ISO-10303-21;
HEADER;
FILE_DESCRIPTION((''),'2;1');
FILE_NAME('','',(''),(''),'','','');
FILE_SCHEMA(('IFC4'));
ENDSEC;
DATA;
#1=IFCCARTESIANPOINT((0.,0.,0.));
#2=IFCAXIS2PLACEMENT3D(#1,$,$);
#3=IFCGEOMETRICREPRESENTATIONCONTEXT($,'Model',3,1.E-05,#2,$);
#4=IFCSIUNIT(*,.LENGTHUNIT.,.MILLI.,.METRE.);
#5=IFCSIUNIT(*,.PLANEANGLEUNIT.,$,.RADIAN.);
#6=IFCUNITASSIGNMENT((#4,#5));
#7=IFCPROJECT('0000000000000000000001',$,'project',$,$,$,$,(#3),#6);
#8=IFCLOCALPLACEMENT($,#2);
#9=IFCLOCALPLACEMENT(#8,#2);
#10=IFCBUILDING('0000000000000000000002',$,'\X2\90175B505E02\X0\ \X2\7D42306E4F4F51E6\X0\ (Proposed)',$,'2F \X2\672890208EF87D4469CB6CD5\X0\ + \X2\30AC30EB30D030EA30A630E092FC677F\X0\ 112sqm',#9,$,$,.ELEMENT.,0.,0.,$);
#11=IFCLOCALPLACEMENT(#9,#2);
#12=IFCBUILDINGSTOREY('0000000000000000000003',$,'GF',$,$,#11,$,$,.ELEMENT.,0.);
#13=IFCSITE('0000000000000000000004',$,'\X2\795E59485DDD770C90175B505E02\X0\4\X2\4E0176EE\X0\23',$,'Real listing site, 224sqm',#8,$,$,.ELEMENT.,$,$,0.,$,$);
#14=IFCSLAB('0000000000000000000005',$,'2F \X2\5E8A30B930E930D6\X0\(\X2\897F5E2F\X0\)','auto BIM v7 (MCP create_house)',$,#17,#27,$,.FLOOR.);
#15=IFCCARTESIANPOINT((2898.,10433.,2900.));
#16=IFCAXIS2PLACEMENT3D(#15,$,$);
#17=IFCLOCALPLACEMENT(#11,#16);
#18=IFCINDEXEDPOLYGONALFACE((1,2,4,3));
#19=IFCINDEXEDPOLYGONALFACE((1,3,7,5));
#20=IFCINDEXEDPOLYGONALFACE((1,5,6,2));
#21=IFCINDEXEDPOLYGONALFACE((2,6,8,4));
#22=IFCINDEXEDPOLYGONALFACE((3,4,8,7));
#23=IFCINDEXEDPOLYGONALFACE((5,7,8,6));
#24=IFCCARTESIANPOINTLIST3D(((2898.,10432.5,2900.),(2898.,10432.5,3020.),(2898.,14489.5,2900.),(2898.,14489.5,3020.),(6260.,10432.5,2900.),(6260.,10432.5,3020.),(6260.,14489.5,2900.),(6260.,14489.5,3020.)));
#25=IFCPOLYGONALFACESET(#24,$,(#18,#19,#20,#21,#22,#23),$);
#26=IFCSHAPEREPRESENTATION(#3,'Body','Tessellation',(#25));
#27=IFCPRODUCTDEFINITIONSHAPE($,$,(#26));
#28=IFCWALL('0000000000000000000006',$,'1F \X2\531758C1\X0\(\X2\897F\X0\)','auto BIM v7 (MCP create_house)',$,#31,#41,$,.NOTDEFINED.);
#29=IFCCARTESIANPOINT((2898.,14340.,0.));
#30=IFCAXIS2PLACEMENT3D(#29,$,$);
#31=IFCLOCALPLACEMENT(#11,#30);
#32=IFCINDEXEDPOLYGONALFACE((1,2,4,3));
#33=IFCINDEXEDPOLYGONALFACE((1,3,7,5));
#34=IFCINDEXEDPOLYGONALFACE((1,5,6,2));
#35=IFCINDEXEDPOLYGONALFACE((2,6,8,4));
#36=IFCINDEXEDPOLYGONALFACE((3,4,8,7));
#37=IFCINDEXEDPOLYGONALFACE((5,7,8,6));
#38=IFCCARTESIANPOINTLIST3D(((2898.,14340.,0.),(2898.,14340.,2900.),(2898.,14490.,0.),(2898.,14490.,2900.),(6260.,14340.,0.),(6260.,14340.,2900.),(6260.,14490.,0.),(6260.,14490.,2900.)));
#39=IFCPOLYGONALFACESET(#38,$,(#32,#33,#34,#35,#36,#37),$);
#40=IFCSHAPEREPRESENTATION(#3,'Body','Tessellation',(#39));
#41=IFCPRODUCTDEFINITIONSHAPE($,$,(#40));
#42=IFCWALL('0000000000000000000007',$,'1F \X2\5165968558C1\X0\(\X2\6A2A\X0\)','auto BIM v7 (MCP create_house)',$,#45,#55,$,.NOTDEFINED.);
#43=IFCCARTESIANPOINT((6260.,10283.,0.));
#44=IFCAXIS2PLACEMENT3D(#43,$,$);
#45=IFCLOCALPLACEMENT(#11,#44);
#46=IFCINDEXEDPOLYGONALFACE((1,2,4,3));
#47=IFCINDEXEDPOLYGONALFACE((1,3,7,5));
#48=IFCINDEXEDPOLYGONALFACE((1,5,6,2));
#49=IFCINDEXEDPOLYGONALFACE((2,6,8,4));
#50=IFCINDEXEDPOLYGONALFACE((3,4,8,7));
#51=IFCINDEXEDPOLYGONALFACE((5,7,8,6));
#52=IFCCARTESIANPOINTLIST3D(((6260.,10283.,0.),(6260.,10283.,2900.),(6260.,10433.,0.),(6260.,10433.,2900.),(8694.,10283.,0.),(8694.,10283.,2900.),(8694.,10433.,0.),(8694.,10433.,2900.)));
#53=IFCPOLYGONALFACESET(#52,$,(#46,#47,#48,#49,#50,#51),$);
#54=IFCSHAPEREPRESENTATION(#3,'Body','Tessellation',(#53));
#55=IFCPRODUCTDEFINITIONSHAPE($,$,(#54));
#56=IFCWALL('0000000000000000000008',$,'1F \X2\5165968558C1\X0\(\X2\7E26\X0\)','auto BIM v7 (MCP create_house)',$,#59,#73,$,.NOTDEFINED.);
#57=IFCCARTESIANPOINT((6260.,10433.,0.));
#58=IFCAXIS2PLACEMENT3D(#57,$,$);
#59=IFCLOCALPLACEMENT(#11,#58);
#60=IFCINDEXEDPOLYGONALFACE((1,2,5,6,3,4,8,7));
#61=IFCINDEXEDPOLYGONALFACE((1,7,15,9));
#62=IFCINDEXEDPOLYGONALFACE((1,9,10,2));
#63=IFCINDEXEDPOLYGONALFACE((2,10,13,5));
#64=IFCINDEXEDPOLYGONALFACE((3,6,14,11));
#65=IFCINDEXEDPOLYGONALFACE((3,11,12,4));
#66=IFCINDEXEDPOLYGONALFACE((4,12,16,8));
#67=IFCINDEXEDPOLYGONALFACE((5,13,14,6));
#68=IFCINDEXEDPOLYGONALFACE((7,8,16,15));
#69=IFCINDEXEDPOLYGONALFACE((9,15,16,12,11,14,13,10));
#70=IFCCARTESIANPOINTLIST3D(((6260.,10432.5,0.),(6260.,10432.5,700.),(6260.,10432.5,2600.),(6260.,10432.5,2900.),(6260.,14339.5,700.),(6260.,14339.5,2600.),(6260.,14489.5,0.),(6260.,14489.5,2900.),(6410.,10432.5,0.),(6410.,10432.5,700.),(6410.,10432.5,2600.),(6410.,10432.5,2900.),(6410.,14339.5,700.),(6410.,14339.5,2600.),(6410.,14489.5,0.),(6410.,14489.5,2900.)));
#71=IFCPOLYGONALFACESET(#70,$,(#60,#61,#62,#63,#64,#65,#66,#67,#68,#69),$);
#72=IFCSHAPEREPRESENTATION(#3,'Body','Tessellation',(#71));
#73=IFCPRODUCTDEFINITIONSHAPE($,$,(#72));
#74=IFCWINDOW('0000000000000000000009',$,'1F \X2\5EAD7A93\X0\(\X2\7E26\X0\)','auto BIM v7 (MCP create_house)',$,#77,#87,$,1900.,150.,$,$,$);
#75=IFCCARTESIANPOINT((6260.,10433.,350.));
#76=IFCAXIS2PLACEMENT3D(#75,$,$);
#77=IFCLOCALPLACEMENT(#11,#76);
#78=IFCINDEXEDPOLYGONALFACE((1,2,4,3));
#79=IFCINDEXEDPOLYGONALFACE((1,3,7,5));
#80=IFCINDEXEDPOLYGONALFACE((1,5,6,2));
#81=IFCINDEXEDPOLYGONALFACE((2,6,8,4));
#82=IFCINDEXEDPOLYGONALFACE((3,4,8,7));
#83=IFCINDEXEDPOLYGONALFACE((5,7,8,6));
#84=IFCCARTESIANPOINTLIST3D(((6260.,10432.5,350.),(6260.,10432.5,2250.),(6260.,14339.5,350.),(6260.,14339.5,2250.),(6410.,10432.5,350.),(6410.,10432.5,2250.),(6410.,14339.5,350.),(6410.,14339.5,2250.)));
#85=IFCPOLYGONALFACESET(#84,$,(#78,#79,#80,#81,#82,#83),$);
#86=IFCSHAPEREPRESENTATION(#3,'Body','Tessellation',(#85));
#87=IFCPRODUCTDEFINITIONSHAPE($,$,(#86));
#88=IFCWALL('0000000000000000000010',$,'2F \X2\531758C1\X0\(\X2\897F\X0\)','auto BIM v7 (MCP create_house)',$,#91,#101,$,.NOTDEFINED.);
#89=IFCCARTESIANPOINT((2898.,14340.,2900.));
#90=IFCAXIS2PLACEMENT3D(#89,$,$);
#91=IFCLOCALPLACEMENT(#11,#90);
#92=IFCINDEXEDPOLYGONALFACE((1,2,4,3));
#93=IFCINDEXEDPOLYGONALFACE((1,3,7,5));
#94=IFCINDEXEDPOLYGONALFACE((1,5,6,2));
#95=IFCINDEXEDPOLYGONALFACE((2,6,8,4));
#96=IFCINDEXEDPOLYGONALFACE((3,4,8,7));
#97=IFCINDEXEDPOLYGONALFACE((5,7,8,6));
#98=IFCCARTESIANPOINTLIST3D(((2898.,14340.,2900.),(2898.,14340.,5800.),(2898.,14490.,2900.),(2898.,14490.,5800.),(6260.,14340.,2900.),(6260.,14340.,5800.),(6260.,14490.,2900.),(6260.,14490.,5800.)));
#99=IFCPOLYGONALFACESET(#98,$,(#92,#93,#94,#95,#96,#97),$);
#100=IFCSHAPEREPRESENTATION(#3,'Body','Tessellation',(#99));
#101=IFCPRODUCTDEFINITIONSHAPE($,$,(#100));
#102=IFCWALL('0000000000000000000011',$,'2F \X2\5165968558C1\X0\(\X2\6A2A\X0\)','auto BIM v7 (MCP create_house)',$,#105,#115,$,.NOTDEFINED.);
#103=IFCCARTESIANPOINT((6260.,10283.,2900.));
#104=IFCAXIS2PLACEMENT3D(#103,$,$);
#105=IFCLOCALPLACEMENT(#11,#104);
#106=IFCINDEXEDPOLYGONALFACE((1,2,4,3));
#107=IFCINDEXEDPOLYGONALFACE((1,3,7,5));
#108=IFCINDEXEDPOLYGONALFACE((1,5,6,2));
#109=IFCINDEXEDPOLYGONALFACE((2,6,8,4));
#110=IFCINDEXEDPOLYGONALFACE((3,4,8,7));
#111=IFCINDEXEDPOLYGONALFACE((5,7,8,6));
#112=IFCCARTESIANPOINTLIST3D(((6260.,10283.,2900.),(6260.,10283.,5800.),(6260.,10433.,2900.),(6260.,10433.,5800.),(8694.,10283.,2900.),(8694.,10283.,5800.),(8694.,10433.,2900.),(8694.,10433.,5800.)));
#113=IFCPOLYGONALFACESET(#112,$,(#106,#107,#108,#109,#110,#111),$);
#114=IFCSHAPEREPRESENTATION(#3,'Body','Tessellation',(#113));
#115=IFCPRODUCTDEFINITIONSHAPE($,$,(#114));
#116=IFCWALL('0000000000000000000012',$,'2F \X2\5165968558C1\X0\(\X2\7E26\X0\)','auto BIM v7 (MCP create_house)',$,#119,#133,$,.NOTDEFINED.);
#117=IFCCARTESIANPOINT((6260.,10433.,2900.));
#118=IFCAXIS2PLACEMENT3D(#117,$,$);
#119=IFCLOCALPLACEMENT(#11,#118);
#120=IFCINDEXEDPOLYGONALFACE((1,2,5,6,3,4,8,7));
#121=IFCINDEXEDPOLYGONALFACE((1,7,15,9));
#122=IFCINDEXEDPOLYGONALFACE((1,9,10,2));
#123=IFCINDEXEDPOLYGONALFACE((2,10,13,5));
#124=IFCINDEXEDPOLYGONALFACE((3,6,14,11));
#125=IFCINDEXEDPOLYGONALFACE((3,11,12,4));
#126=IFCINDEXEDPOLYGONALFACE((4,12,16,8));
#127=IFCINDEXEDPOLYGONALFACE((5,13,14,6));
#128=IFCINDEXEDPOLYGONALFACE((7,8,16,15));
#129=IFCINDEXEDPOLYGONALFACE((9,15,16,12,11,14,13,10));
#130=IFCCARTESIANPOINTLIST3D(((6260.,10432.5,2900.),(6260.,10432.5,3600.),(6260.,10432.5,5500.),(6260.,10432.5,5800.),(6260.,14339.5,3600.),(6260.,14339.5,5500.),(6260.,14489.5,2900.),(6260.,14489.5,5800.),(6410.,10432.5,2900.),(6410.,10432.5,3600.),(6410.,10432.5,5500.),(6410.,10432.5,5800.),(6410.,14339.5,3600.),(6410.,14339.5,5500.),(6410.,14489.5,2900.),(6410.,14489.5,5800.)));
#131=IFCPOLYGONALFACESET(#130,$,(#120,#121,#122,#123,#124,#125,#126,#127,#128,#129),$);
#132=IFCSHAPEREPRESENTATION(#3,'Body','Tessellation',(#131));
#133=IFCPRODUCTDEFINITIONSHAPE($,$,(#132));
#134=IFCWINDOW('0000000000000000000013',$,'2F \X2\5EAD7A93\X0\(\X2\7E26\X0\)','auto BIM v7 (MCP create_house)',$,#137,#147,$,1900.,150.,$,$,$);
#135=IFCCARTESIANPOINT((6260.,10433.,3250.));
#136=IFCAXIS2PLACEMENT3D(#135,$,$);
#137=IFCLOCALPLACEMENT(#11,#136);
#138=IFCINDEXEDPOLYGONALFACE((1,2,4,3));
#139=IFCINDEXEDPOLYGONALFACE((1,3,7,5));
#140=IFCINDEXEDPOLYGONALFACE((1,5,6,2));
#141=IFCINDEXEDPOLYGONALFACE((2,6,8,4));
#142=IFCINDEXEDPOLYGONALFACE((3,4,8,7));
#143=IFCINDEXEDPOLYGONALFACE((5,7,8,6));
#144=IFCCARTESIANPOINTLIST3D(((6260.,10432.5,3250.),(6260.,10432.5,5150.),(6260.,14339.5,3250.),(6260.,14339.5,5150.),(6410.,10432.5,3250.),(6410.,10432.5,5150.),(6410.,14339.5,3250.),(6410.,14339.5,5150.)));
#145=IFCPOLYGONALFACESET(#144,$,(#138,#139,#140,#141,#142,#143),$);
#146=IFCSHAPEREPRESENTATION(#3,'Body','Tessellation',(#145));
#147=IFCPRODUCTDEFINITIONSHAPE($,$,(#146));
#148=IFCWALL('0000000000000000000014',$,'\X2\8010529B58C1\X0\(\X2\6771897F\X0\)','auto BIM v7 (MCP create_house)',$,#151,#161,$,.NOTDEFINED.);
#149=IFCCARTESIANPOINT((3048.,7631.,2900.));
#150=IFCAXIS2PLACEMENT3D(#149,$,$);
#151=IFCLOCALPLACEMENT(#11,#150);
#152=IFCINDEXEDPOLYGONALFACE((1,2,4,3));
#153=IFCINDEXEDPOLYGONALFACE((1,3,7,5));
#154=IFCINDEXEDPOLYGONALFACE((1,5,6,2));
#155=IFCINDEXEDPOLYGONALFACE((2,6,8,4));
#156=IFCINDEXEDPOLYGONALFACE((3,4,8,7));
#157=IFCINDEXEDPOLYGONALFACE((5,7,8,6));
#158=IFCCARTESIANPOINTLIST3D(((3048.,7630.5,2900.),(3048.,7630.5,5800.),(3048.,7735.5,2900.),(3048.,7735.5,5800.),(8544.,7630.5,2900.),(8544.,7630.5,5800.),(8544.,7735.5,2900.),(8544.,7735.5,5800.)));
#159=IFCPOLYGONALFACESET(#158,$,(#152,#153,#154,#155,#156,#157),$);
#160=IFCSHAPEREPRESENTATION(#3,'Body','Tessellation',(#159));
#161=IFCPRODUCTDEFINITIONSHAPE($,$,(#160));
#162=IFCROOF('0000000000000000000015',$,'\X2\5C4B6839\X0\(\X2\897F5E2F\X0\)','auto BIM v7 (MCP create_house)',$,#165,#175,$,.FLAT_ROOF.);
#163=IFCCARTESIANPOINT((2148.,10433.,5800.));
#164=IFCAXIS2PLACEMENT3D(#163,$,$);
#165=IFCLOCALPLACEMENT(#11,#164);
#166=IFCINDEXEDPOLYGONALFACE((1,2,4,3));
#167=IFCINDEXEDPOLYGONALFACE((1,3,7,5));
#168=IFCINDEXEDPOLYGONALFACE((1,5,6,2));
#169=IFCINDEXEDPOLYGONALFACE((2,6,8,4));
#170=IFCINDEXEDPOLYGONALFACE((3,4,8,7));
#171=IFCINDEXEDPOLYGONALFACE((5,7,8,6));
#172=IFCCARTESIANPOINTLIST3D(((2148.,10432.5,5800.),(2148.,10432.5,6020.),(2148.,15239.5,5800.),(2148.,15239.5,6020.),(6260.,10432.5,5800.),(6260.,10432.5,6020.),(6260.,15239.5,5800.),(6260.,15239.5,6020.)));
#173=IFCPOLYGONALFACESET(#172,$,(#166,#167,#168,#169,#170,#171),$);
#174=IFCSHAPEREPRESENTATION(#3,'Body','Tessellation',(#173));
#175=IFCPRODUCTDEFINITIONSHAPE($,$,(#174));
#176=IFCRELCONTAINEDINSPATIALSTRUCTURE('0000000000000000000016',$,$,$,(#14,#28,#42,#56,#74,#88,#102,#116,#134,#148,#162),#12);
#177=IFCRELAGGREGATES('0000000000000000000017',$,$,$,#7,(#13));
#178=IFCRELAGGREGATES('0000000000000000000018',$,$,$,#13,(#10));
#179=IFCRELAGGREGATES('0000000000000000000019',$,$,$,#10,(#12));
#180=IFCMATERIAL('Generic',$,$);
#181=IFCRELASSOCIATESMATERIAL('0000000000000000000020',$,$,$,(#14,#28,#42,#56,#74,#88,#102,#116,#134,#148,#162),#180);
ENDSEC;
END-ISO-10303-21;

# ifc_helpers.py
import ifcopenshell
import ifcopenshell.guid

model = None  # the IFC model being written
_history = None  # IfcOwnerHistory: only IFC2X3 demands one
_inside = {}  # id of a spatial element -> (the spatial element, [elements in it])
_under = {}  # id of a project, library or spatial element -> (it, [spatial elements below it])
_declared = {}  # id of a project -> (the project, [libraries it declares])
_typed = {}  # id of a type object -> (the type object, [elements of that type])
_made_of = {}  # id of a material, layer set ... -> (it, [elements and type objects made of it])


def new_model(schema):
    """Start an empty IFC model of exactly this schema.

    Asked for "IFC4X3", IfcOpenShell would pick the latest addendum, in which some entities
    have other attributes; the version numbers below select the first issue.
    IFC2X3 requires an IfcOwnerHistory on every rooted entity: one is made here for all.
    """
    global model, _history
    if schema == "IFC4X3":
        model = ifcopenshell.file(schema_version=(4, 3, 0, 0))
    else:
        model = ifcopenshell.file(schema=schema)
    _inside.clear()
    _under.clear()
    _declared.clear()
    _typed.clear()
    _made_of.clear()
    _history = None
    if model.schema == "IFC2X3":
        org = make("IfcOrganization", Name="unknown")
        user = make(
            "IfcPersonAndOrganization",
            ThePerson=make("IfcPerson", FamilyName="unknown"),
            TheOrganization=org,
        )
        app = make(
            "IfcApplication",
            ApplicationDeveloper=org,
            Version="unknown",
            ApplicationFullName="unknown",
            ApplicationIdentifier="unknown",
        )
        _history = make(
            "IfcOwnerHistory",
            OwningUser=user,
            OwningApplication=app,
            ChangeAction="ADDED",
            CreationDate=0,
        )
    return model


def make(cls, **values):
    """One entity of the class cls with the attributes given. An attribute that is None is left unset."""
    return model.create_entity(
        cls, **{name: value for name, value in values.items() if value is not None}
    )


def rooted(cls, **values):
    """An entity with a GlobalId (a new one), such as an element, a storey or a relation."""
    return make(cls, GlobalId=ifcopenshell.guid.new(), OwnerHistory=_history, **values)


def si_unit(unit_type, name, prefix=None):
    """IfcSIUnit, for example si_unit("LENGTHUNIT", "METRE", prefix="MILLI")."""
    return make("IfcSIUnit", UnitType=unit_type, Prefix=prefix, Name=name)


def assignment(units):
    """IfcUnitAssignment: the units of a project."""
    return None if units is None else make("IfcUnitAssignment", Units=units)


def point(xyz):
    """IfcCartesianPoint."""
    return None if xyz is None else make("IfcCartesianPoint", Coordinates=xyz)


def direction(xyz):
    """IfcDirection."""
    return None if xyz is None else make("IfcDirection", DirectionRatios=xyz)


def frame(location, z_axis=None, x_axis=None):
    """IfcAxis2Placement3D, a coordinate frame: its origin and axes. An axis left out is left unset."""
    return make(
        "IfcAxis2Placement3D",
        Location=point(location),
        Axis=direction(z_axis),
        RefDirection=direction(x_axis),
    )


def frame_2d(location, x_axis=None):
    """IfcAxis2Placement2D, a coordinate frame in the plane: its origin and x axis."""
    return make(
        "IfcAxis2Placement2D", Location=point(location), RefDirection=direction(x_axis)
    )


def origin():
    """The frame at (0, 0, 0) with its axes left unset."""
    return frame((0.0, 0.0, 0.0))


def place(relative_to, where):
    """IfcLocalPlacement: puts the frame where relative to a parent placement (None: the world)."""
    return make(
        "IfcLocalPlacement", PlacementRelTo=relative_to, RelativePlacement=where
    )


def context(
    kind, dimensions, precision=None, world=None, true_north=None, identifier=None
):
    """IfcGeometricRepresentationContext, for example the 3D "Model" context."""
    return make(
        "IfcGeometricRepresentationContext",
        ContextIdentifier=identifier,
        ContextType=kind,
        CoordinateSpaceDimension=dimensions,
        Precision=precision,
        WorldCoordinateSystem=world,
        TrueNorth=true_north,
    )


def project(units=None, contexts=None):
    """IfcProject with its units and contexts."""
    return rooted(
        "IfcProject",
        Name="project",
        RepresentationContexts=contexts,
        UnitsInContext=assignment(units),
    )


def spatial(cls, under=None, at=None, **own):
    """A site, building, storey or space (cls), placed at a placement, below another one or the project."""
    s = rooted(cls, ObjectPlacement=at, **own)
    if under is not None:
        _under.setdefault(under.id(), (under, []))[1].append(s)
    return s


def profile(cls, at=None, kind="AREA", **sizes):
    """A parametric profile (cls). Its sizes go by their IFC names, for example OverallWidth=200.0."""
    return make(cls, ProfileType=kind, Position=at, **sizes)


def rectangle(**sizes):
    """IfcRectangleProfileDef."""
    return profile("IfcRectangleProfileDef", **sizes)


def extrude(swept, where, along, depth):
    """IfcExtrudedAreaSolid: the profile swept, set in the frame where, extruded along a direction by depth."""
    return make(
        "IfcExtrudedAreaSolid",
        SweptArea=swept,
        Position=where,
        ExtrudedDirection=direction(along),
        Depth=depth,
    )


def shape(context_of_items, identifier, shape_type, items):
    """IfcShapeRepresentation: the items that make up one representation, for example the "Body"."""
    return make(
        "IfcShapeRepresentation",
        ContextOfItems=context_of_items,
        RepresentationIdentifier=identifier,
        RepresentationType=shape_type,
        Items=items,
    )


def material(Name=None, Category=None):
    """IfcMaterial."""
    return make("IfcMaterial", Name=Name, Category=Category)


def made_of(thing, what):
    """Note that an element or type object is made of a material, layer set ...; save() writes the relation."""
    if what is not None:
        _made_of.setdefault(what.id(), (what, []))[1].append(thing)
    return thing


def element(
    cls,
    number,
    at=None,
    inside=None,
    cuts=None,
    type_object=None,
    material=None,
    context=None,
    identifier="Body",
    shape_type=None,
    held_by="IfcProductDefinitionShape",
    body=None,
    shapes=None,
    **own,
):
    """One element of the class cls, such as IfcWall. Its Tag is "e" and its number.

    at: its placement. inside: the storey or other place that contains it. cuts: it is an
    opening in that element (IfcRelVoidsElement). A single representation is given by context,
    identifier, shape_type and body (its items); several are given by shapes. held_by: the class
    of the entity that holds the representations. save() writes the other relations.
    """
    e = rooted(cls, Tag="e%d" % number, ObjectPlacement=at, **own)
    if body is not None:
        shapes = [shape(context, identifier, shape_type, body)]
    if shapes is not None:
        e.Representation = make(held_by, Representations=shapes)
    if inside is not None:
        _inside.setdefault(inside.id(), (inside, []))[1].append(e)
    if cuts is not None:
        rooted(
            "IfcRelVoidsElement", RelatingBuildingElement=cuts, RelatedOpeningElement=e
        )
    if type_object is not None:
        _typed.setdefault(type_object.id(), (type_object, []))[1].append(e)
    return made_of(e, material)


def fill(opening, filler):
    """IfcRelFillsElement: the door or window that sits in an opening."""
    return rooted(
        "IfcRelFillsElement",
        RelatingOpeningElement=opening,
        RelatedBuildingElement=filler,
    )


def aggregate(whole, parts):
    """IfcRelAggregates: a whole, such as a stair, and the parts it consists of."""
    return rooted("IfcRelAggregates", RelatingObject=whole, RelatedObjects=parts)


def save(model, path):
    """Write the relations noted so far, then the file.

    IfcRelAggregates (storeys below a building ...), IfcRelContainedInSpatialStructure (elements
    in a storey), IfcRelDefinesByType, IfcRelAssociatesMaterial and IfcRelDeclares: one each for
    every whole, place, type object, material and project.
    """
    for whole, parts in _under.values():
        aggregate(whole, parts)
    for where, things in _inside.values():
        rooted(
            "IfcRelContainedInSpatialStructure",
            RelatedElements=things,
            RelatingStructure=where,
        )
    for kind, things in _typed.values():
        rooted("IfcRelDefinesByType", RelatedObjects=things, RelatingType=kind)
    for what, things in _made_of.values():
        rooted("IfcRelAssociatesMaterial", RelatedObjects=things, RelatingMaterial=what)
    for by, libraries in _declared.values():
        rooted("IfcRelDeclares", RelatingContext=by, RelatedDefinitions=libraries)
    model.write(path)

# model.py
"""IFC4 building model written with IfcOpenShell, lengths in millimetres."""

from ifc_helpers import new_model, si_unit, frame, frame_2d, origin, place, context, project, spatial, rectangle, extrude, material, element, fill, save


model = new_model("IFC4")

# Units and contexts
model_context = context("Model", 3, precision=1e-05, world=origin())
ifc_project = project(units=[si_unit("LENGTHUNIT", "METRE", prefix="MILLI"), si_unit("PLANEANGLEUNIT", "RADIAN")], contexts=[model_context])

# Site, building, storey
site_placement = place(None, origin())
site = spatial("IfcSite", under=ifc_project, at=site_placement, Name="神奈川県逗子市4丁目23", ObjectType="Real listing site, 224sqm", CompositionType="ELEMENT", RefElevation=0.0)
building_placement = place(site_placement, origin())
building = spatial("IfcBuilding", under=site, at=building_placement, Name="逗子市 終の住処 (Proposed)", ObjectType="2F 木造軸組構法 + ガルバリウム鋼板 112sqm", CompositionType="ELEMENT", ElevationOfRefHeight=0.0, ElevationOfTerrain=0.0)
storey_placement = place(building_placement, origin())
storey = spatial("IfcBuildingStorey", under=building, at=storey_placement, Name="GF", CompositionType="ELEMENT", Elevation=0.0)

# Slab
ifc_material = material(Name="Generic")
slab_1_placement = place(storey_placement, frame((2898.0, 10433.0, 2900.0)))
element("IfcSlab", 1, at=slab_1_placement, inside=storey, material=ifc_material, Name="2F 床スラブ(西帯)", Description="auto BIM v7 (MCP create_house)", PredefinedType="FLOOR", context=model_context, shape_type="SweptSolid", body=[
    extrude(rectangle(XDim=3362.0, YDim=4057.0, at=frame_2d((1681.0, 2028.0))), frame((2898.0, 10433.0, 2900.0)), (0.0, 0.0, 1.0), 120.0),
])

# Walls
wall_1_placement = place(storey_placement, frame((2898.0, 14340.0, 0.0)))
element("IfcWall", 2, at=wall_1_placement, inside=storey, material=ifc_material, Name="1F 北壁(西)", Description="auto BIM v7 (MCP create_house)", PredefinedType="NOTDEFINED", context=model_context, shape_type="SweptSolid", body=[
    extrude(rectangle(XDim=3362.0, YDim=150.0, at=frame_2d((1681.0, 75.0))), frame((2898.0, 14340.0, 0.0)), (0.0, 0.0, 1.0), 2900.0),
])
wall_2_placement = place(storey_placement, frame((6260.0, 10283.0, 0.0)))
element("IfcWall", 3, at=wall_2_placement, inside=storey, material=ifc_material, Name="1F 入隅壁(横)", Description="auto BIM v7 (MCP create_house)", PredefinedType="NOTDEFINED", context=model_context, shape_type="SweptSolid", body=[
    extrude(rectangle(XDim=2434.0, YDim=150.0, at=frame_2d((1217.0, 75.0))), frame((6260.0, 10283.0, 0.0)), (0.0, 0.0, 1.0), 2900.0),
])

# Wall, opening, window
wall_3_placement = place(storey_placement, frame((6260.0, 10433.0, 0.0)))
wall_3 = element("IfcWall", 4, at=wall_3_placement, inside=storey, material=ifc_material, Name="1F 入隅壁(縦)", Description="auto BIM v7 (MCP create_house)", PredefinedType="NOTDEFINED", context=model_context, shape_type="SweptSolid", body=[
    extrude(rectangle(XDim=150.0, YDim=4057.0, at=frame_2d((75.0, 2028.0))), frame((6260.0, 10433.0, 0.0)), (0.0, 0.0, 1.0), 2900.0),
])
opening_1_placement = place(storey_placement, frame((6260.0, 10433.0, 350.0)))
opening_1 = element("IfcOpeningElement", 5, at=opening_1_placement, cuts=wall_3, PredefinedType="NOTDEFINED", context=model_context, shape_type="SweptSolid", body=[
    extrude(rectangle(XDim=150.0, YDim=3907.0, at=frame_2d((75.0, 1953.0))), frame((6260.0, 10433.0, 350.0)), (0.0, 0.0, 1.0), 1900.0),
])
window_1_placement = place(storey_placement, frame((6260.0, 10433.0, 350.0)))
window_1 = element("IfcWindow", 6, at=window_1_placement, inside=storey, material=ifc_material, Name="1F 庭窓(縦)", Description="auto BIM v7 (MCP create_house)", OverallHeight=1900.0, OverallWidth=150.0, context=model_context, shape_type="SweptSolid", body=[
    extrude(rectangle(XDim=150.0, YDim=3907.0, at=frame_2d((75.0, 1953.0))), frame((6260.0, 10433.0, 350.0)), (0.0, 0.0, 1.0), 1900.0),
])
fill(opening_1, window_1)

# Walls
wall_4_placement = place(storey_placement, frame((2898.0, 14340.0, 2900.0)))
element("IfcWall", 7, at=wall_4_placement, inside=storey, material=ifc_material, Name="2F 北壁(西)", Description="auto BIM v7 (MCP create_house)", PredefinedType="NOTDEFINED", context=model_context, shape_type="SweptSolid", body=[
    extrude(rectangle(XDim=3362.0, YDim=150.0, at=frame_2d((1681.0, 75.0))), frame((2898.0, 14340.0, 2900.0)), (0.0, 0.0, 1.0), 2900.0),
])
wall_5_placement = place(storey_placement, frame((6260.0, 10283.0, 2900.0)))
element("IfcWall", 8, at=wall_5_placement, inside=storey, material=ifc_material, Name="2F 入隅壁(横)", Description="auto BIM v7 (MCP create_house)", PredefinedType="NOTDEFINED", context=model_context, shape_type="SweptSolid", body=[
    extrude(rectangle(XDim=2434.0, YDim=150.0, at=frame_2d((1217.0, 75.0))), frame((6260.0, 10283.0, 2900.0)), (0.0, 0.0, 1.0), 2900.0),
])

# Wall, opening, window
wall_6_placement = place(storey_placement, frame((6260.0, 10433.0, 2900.0)))
wall_6 = element("IfcWall", 9, at=wall_6_placement, inside=storey, material=ifc_material, Name="2F 入隅壁(縦)", Description="auto BIM v7 (MCP create_house)", PredefinedType="NOTDEFINED", context=model_context, shape_type="SweptSolid", body=[
    extrude(rectangle(XDim=150.0, YDim=4057.0, at=frame_2d((75.0, 2028.0))), frame((6260.0, 10433.0, 2900.0)), (0.0, 0.0, 1.0), 2900.0),
])
opening_2_placement = place(storey_placement, frame((6260.0, 10433.0, 3250.0)))
opening_2 = element("IfcOpeningElement", 10, at=opening_2_placement, cuts=wall_6, PredefinedType="NOTDEFINED", context=model_context, shape_type="SweptSolid", body=[
    extrude(rectangle(XDim=150.0, YDim=3907.0, at=frame_2d((75.0, 1953.0))), frame((6260.0, 10433.0, 3250.0)), (0.0, 0.0, 1.0), 1900.0),
])
window_2_placement = place(storey_placement, frame((6260.0, 10433.0, 3250.0)))
window_2 = element("IfcWindow", 11, at=window_2_placement, inside=storey, material=ifc_material, Name="2F 庭窓(縦)", Description="auto BIM v7 (MCP create_house)", OverallHeight=1900.0, OverallWidth=150.0, context=model_context, shape_type="SweptSolid", body=[
    extrude(rectangle(XDim=150.0, YDim=3907.0, at=frame_2d((75.0, 1953.0))), frame((6260.0, 10433.0, 3250.0)), (0.0, 0.0, 1.0), 1900.0),
])
fill(opening_2, window_2)

# Wall
wall_7_placement = place(storey_placement, frame((3048.0, 7631.0, 2900.0)))
element("IfcWall", 12, at=wall_7_placement, inside=storey, material=ifc_material, Name="耐力壁(東西)", Description="auto BIM v7 (MCP create_house)", PredefinedType="NOTDEFINED", context=model_context, shape_type="SweptSolid", body=[
    extrude(rectangle(XDim=5496.0, YDim=105.0, at=frame_2d((2748.0, 52.0))), frame((3048.0, 7631.0, 2900.0)), (0.0, 0.0, 1.0), 2900.0),
])

# Roof
for number, where, name in (
    (13, (2148.0, 10433.0, 5800.0), "屋根(西帯)"),
):
    element("IfcRoof", number, at=place(storey_placement, frame(where)), inside=storey, material=ifc_material, Name=name, Description="auto BIM v7 (MCP create_house)", PredefinedType="FLAT_ROOF", context=model_context, shape_type="SweptSolid", body=[
        extrude(rectangle(XDim=4112.0, YDim=4807.0, at=frame_2d((2056.0, 2403.0))), frame((2148.0, 10433.0, 5800.0)), (0.0, 0.0, 1.0), 220.0),
    ])

save(model, "model.ifc")
